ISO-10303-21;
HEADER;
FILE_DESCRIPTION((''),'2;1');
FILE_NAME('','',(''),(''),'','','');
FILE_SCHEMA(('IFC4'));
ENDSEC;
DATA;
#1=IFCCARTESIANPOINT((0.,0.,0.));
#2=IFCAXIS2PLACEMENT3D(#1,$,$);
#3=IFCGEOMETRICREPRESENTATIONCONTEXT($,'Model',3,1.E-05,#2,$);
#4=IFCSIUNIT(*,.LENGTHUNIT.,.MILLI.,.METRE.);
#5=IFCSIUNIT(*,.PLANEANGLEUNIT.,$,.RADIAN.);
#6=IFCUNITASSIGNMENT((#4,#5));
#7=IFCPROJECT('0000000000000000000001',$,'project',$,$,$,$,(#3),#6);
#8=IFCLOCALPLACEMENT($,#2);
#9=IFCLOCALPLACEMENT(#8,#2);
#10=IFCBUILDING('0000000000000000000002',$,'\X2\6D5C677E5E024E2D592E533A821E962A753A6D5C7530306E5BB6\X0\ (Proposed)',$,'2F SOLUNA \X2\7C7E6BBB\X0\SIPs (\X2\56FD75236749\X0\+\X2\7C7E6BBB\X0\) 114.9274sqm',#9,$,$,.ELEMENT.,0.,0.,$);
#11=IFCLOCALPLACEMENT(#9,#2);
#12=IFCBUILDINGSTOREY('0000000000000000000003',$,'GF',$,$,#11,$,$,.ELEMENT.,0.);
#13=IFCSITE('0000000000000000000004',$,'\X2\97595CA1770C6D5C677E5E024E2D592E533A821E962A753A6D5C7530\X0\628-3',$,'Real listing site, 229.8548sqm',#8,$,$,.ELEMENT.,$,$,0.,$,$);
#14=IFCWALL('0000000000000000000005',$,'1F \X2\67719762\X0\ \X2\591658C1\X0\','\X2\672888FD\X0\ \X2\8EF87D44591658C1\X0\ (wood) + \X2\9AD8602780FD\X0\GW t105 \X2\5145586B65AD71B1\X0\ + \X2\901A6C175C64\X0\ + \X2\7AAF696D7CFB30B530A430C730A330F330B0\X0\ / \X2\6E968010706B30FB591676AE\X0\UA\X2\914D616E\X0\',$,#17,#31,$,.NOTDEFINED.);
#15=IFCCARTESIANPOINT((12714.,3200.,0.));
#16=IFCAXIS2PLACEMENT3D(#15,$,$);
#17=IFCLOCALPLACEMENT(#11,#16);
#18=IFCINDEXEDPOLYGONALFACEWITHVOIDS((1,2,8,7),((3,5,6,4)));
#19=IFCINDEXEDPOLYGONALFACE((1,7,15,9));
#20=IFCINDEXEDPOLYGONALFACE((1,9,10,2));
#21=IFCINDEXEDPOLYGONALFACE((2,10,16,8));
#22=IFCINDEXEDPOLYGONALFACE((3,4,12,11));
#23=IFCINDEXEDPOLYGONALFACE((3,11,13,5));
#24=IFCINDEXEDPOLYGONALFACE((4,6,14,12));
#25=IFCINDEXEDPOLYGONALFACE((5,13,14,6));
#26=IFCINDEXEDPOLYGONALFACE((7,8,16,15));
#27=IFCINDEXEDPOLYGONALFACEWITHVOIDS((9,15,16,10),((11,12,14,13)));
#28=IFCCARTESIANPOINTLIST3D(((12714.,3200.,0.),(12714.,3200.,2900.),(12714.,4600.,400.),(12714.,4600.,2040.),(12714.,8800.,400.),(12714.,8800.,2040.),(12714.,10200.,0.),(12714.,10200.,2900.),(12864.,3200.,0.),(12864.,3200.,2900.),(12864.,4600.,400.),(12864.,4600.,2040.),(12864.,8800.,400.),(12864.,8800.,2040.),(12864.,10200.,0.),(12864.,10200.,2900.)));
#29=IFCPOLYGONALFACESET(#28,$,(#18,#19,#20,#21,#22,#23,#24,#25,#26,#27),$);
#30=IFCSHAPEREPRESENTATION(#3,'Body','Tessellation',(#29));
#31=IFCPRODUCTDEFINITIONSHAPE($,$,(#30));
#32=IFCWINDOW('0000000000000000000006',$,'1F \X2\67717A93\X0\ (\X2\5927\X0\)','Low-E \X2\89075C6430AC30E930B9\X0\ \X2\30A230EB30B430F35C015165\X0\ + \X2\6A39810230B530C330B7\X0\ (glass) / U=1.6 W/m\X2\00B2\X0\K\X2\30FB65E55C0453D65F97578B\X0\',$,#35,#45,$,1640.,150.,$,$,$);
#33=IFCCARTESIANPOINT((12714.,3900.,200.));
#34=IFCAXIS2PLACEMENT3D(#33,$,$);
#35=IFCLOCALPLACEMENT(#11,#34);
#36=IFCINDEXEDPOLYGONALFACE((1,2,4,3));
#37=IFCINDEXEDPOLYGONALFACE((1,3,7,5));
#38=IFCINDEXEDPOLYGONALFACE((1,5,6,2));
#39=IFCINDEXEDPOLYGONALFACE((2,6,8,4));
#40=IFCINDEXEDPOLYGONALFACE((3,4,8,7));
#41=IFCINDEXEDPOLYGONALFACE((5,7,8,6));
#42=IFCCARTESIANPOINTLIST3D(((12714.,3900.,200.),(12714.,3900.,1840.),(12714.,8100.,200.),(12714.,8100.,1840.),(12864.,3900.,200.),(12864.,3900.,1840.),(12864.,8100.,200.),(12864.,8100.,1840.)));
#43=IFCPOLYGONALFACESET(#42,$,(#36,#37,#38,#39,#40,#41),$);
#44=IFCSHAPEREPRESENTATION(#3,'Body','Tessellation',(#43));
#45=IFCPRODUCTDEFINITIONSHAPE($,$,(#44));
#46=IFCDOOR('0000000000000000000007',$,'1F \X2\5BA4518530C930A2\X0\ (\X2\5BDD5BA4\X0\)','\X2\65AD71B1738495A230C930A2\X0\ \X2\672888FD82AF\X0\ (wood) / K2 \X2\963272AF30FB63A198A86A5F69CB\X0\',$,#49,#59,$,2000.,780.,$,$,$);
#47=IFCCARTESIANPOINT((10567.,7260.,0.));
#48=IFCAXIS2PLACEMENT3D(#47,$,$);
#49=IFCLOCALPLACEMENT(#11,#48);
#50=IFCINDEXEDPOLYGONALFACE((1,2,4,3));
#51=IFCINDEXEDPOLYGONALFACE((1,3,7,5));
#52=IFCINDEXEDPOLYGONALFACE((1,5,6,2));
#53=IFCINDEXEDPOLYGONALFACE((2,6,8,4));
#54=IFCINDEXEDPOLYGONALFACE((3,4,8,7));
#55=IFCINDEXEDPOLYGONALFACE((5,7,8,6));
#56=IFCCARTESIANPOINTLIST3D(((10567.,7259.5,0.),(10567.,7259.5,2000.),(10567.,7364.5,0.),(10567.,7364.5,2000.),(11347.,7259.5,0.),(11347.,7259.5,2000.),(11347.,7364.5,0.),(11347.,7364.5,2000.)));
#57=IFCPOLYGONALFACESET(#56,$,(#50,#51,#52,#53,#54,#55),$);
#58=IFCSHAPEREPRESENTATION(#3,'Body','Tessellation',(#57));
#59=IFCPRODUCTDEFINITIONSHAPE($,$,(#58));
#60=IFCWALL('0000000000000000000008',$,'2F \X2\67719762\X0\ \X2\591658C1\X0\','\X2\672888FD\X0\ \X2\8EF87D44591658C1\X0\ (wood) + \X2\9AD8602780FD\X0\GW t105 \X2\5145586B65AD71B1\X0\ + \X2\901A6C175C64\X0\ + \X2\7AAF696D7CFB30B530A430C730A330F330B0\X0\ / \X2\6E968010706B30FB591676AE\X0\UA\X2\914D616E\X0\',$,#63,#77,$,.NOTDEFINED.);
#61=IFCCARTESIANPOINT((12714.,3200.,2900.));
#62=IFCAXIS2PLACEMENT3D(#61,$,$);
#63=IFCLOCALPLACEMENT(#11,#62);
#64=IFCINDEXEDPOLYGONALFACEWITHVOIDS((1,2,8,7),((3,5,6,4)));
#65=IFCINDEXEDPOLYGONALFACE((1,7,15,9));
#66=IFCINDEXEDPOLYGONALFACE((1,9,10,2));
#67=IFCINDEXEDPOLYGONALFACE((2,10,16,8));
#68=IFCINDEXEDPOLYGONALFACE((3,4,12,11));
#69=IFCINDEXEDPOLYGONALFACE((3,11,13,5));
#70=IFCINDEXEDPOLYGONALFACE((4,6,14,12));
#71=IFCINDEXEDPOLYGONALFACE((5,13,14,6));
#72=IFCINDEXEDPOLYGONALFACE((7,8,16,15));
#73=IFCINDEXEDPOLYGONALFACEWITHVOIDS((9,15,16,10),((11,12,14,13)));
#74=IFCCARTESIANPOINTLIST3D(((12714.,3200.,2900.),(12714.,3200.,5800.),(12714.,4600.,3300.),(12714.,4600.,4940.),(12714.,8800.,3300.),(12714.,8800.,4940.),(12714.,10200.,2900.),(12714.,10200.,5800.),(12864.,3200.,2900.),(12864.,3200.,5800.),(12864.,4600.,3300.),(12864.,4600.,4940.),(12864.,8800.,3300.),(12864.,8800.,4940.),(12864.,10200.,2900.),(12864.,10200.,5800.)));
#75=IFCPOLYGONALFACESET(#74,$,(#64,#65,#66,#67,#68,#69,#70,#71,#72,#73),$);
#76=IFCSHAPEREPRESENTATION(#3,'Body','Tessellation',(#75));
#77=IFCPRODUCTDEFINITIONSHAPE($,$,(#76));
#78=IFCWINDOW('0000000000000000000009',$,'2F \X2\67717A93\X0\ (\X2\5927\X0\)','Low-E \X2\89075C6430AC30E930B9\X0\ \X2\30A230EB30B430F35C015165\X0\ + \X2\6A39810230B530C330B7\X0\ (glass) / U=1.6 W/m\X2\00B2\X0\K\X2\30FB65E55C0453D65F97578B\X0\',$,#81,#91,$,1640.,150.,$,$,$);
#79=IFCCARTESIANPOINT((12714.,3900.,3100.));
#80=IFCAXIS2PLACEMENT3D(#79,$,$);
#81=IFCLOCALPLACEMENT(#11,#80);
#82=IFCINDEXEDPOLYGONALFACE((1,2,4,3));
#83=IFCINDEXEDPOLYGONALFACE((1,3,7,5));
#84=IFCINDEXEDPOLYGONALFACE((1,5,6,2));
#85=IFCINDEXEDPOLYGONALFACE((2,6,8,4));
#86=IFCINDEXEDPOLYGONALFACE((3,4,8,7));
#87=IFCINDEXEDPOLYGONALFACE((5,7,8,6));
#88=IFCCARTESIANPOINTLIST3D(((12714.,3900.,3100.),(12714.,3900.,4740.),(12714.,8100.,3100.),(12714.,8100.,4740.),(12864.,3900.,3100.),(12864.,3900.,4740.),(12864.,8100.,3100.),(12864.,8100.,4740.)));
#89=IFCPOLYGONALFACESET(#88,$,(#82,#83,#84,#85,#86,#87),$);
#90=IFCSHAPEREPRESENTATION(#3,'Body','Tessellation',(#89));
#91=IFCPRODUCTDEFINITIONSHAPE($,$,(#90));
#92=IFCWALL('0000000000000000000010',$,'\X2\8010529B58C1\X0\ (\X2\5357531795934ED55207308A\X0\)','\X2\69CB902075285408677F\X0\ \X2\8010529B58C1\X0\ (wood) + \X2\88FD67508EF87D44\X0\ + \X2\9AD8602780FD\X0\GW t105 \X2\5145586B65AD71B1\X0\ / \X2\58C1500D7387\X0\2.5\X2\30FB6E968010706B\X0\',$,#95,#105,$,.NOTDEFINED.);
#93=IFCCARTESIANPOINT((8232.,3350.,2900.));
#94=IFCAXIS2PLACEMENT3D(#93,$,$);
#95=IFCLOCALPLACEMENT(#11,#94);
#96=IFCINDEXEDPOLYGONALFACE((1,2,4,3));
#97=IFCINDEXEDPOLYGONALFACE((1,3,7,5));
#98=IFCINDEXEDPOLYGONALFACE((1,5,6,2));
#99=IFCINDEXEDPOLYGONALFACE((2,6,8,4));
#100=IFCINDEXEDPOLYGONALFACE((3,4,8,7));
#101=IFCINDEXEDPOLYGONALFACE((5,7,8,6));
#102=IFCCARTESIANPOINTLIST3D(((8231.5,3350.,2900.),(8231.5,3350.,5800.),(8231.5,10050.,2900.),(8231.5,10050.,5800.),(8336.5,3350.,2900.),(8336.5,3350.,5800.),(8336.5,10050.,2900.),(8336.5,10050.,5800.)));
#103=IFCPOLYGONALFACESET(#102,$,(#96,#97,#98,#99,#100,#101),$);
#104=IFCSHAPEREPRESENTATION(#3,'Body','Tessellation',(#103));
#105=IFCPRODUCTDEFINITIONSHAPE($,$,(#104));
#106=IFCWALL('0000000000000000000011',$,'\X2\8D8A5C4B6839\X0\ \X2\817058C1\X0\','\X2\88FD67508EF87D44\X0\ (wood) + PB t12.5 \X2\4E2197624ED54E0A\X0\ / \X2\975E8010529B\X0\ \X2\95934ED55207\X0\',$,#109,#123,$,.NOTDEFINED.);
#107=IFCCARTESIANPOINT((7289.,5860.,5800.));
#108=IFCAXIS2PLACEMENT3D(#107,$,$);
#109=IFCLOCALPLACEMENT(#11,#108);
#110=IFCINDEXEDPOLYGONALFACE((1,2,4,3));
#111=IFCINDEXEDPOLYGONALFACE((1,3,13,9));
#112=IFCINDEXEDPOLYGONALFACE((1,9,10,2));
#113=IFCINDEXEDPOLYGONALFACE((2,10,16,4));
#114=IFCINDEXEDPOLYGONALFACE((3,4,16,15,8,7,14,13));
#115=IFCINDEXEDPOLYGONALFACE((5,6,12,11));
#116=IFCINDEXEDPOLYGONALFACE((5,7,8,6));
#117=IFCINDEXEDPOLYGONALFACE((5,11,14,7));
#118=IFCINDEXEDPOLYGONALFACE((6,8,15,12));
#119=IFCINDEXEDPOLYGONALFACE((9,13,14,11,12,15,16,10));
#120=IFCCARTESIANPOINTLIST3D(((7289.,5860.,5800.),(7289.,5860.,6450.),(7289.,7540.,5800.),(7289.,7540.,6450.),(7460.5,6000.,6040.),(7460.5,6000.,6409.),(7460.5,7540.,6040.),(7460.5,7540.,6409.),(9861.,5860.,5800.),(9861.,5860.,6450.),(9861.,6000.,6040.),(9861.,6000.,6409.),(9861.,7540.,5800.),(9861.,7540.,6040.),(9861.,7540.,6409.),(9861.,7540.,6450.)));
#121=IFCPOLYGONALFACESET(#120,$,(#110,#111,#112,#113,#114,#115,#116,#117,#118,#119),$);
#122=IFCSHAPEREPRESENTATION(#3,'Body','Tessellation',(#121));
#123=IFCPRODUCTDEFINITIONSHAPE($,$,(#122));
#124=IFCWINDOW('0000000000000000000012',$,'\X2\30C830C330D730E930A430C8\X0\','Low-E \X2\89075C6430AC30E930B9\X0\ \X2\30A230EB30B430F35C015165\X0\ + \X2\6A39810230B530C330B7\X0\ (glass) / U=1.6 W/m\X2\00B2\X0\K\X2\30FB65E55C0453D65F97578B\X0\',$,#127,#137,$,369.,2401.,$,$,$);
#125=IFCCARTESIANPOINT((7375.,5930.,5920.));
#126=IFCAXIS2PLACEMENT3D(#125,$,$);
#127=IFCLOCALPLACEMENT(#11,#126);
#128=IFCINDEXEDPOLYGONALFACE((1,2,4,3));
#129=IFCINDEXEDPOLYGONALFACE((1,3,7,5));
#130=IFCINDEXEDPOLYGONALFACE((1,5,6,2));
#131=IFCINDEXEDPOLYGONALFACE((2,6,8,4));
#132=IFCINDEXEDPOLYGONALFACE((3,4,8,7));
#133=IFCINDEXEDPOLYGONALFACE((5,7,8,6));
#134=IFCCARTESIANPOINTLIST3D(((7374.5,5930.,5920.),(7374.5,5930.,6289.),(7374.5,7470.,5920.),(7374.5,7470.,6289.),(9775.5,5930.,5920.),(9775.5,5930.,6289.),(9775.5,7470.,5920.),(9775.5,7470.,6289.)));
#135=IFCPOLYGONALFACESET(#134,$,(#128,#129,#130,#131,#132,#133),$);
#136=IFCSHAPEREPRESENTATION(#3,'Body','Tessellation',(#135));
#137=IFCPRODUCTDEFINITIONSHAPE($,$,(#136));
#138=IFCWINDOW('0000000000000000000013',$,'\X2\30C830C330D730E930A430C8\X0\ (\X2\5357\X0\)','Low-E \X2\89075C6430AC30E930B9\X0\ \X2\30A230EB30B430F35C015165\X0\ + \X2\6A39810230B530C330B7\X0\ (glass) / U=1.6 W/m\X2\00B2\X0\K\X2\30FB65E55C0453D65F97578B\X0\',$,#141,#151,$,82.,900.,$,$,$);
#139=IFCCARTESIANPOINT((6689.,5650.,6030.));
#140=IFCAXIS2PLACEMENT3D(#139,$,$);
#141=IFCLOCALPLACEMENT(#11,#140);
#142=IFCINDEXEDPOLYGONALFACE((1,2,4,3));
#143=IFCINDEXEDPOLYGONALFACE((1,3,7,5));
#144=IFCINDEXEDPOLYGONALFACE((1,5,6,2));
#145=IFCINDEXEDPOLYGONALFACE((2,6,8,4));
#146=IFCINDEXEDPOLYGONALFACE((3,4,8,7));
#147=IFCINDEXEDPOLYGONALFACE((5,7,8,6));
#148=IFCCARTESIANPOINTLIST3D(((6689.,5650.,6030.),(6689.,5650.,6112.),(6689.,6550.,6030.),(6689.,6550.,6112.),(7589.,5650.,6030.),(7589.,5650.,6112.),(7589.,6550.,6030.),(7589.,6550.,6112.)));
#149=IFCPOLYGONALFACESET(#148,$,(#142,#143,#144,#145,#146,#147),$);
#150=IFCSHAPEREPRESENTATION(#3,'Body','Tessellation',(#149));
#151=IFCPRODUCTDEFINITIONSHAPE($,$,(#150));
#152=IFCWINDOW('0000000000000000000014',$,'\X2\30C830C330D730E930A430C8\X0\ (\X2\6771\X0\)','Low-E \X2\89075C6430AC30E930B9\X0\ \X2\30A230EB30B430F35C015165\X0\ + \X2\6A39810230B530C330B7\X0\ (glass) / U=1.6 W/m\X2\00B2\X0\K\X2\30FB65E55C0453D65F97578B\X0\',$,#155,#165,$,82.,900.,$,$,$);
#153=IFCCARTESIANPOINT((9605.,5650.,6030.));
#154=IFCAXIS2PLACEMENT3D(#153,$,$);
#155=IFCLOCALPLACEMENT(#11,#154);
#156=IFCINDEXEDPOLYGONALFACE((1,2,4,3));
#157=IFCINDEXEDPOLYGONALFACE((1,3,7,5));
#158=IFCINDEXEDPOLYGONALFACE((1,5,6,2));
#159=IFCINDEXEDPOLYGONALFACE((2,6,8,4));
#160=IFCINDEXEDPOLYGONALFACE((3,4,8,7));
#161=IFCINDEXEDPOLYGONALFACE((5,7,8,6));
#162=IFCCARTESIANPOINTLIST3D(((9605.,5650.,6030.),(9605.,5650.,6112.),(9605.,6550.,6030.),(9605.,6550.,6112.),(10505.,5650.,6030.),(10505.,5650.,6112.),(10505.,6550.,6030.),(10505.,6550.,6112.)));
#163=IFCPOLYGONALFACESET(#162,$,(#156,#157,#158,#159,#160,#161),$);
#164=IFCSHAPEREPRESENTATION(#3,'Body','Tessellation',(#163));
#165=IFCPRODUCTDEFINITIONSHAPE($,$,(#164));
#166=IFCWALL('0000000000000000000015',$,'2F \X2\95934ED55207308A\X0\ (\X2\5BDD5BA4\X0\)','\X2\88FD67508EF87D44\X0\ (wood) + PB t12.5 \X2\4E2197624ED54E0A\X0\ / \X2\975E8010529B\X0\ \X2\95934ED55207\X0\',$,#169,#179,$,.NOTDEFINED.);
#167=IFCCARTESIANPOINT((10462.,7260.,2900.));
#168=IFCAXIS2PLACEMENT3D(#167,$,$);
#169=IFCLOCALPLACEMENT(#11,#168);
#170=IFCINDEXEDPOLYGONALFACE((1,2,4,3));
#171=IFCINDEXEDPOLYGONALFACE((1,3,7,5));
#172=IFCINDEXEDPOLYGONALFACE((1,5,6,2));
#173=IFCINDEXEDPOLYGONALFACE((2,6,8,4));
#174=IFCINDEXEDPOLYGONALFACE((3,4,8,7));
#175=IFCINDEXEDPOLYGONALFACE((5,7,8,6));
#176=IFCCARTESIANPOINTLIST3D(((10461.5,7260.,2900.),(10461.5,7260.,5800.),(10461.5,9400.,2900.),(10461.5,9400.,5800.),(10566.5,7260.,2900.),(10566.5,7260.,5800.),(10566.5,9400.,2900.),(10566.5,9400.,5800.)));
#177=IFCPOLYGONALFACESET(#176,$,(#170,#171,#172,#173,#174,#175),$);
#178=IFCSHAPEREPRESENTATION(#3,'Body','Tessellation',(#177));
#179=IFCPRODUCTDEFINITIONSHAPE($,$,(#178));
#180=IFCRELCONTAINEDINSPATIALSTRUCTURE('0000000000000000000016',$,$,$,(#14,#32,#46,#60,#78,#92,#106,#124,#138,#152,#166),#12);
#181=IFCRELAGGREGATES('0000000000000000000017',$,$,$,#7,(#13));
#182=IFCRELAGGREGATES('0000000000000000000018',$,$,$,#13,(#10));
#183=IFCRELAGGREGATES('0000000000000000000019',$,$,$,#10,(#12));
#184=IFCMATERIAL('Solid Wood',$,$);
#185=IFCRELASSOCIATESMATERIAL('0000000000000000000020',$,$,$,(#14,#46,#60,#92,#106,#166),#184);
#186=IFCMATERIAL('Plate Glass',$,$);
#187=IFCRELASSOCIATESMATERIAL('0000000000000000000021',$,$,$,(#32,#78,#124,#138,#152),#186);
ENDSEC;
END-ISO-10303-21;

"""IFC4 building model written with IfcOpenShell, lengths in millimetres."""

from ifc_helpers import new_model, si_unit, frame, frame_2d, origin, place, context, project, spatial, rectangle, extrude, material, element, fill, save


model = new_model("IFC4")

# Units and contexts
model_context = context("Model", 3, precision=1e-05, world=origin())
ifc_project = project(units=[si_unit("LENGTHUNIT", "METRE", prefix="MILLI"), si_unit("PLANEANGLEUNIT", "RADIAN")], contexts=[model_context])

# Site, building, storey
site_placement = place(None, origin())
site = spatial("IfcSite", under=ifc_project, at=site_placement, Name="静岡県浜松市中央区舞阪町浜田628-3", ObjectType="Real listing site, 229.8548sqm", CompositionType="ELEMENT", RefElevation=0.0)
building_placement = place(site_placement, origin())
building = spatial("IfcBuilding", under=site, at=building_placement, Name="浜松市中央区舞阪町浜田の家 (Proposed)", ObjectType="2F SOLUNA 籾殻SIPs (国産杉+籾殻) 114.9274sqm", CompositionType="ELEMENT", ElevationOfRefHeight=0.0, ElevationOfTerrain=0.0)
storey_placement = place(building_placement, origin())
storey = spatial("IfcBuildingStorey", under=building, at=storey_placement, Name="GF", CompositionType="ELEMENT", Elevation=0.0)

# Wall, opening, window
ifc_material_1 = material(Name="Solid Wood")
wall_1_placement = place(storey_placement, frame((12714.0, 3200.0, 0.0)))
wall_1 = element("IfcWall", 1, at=wall_1_placement, inside=storey, material=ifc_material_1, Name="1F 東面 外壁", Description="木製 軸組外壁 (wood) + 高性能GW t105 充填断熱 + 通気層 + 窯業系サイディング / 準耐火・外皮UA配慮", PredefinedType="NOTDEFINED", context=model_context, shape_type="SweptSolid", body=[
    extrude(rectangle(XDim=150.0, YDim=7000.0, at=frame_2d((75.0, 3500.0))), frame((12714.0, 3200.0, 0.0)), (0.0, 0.0, 1.0), 2900.0),
])
opening_1_placement = place(storey_placement, frame((12714.0, 3900.0, 200.0)))
opening_1 = element("IfcOpeningElement", 2, at=opening_1_placement, cuts=wall_1, PredefinedType="NOTDEFINED", context=model_context, shape_type="SweptSolid", body=[
    extrude(rectangle(XDim=150.0, YDim=4200.0, at=frame_2d((75.0, 2100.0))), frame((12714.0, 3900.0, 200.0)), (0.0, 0.0, 1.0), 1640.0),
])
ifc_material_2 = material(Name="Plate Glass")
window_1_placement = place(storey_placement, frame((12714.0, 3900.0, 200.0)))
window_1 = element("IfcWindow", 3, at=window_1_placement, inside=storey, material=ifc_material_2, Name="1F 東窓 (大)", Description="Low-E 複層ガラス アルゴン封入 + 樹脂サッシ (glass) / U=1.6 W/m²K・日射取得型", OverallHeight=1640.0, OverallWidth=150.0, context=model_context, shape_type="SweptSolid", body=[
    extrude(rectangle(XDim=150.0, YDim=4200.0, at=frame_2d((75.0, 2100.0))), frame((12714.0, 3900.0, 200.0)), (0.0, 0.0, 1.0), 1640.0),
])
fill(opening_1, window_1)

# Door
door_1_placement = place(storey_placement, frame((10567.0, 7260.0, 0.0)))
element("IfcDoor", 4, at=door_1_placement, inside=storey, material=ifc_material_1, Name="1F 室内ドア (寝室)", Description="断熱玄関ドア 木製芯 (wood) / K2 防犯・採風機構", OverallHeight=2000.0, OverallWidth=780.0, context=model_context, shape_type="SweptSolid", body=[
    extrude(rectangle(XDim=780.0, YDim=105.0, at=frame_2d((390.0, 52.0))), frame((10567.0, 7260.0, 0.0)), (0.0, 0.0, 1.0), 2000.0),
])

# Wall, opening, window
wall_2_placement = place(storey_placement, frame((12714.0, 3200.0, 2900.0)))
wall_2 = element("IfcWall", 5, at=wall_2_placement, inside=storey, material=ifc_material_1, Name="2F 東面 外壁", Description="木製 軸組外壁 (wood) + 高性能GW t105 充填断熱 + 通気層 + 窯業系サイディング / 準耐火・外皮UA配慮", PredefinedType="NOTDEFINED", context=model_context, shape_type="SweptSolid", body=[
    extrude(rectangle(XDim=150.0, YDim=7000.0, at=frame_2d((75.0, 3500.0))), frame((12714.0, 3200.0, 2900.0)), (0.0, 0.0, 1.0), 2900.0),
])
opening_2_placement = place(storey_placement, frame((12714.0, 3900.0, 3100.0)))
opening_2 = element("IfcOpeningElement", 6, at=opening_2_placement, cuts=wall_2, PredefinedType="NOTDEFINED", context=model_context, shape_type="SweptSolid", body=[
    extrude(rectangle(XDim=150.0, YDim=4200.0, at=frame_2d((75.0, 2100.0))), frame((12714.0, 3900.0, 3100.0)), (0.0, 0.0, 1.0), 1640.0),
])
window_2_placement = place(storey_placement, frame((12714.0, 3900.0, 3100.0)))
window_2 = element("IfcWindow", 7, at=window_2_placement, inside=storey, material=ifc_material_2, Name="2F 東窓 (大)", Description="Low-E 複層ガラス アルゴン封入 + 樹脂サッシ (glass) / U=1.6 W/m²K・日射取得型", OverallHeight=1640.0, OverallWidth=150.0, context=model_context, shape_type="SweptSolid", body=[
    extrude(rectangle(XDim=150.0, YDim=4200.0, at=frame_2d((75.0, 2100.0))), frame((12714.0, 3900.0, 3100.0)), (0.0, 0.0, 1.0), 1640.0),
])
fill(opening_2, window_2)

# Wall
wall_3_placement = place(storey_placement, frame((8232.0, 3350.0, 2900.0)))
element("IfcWall", 8, at=wall_3_placement, inside=storey, material=ifc_material_1, Name="耐力壁 (南北間仕切り)", Description="構造用合板 耐力壁 (wood) + 製材軸組 + 高性能GW t105 充填断熱 / 壁倍率2.5・準耐火", PredefinedType="NOTDEFINED", context=model_context, shape_type="SweptSolid", body=[
    extrude(rectangle(XDim=105.0, YDim=6700.0, at=frame_2d((52.0, 3350.0))), frame((8232.0, 3350.0, 2900.0)), (0.0, 0.0, 1.0), 2900.0),
])

# Wall, openings, windows
wall_4_placement = place(storey_placement, frame((7289.0, 5860.0, 5800.0)))
wall_4 = element("IfcWall", 9, at=wall_4_placement, inside=storey, material=ifc_material_1, Name="越屋根 腰壁", Description="製材軸組 (wood) + PB t12.5 両面仕上 / 非耐力 間仕切", PredefinedType="NOTDEFINED", context=model_context, shape_type="SweptSolid", body=[
    extrude(rectangle(XDim=2572.0, YDim=1680.0, at=frame_2d((1286.0, 840.0))), frame((7289.0, 5860.0, 5800.0)), (0.0, 0.0, 1.0), 650.0),
])
opening_3_placement = place(storey_placement, frame((7375.0, 5930.0, 5920.0)))
opening_3 = element("IfcOpeningElement", 10, at=opening_3_placement, cuts=wall_4, PredefinedType="NOTDEFINED", context=model_context, shape_type="SweptSolid", body=[
    extrude(rectangle(XDim=2401.0, YDim=1540.0, at=frame_2d((1200.0, 770.0))), frame((7375.0, 5930.0, 5920.0)), (0.0, 0.0, 1.0), 369.0),
])
opening_4_placement = place(storey_placement, frame((6689.0, 5650.0, 6030.0)))
opening_4 = element("IfcOpeningElement", 11, at=opening_4_placement, cuts=wall_4, PredefinedType="NOTDEFINED", context=model_context, shape_type="SweptSolid", body=[
    extrude(rectangle(XDim=900.0, YDim=900.0, at=frame_2d((450.0, 450.0))), frame((6689.0, 5650.0, 6030.0)), (0.0, 0.0, 1.0), 82.0),
])
opening_5_placement = place(storey_placement, frame((9605.0, 5650.0, 6030.0)))
opening_5 = element("IfcOpeningElement", 12, at=opening_5_placement, cuts=wall_4, PredefinedType="NOTDEFINED", context=model_context, shape_type="SweptSolid", body=[
    extrude(rectangle(XDim=900.0, YDim=900.0, at=frame_2d((450.0, 450.0))), frame((9605.0, 5650.0, 6030.0)), (0.0, 0.0, 1.0), 82.0),
])
window_3_placement = place(storey_placement, frame((7375.0, 5930.0, 5920.0)))
window_3 = element("IfcWindow", 13, at=window_3_placement, inside=storey, material=ifc_material_2, Name="トップライト", Description="Low-E 複層ガラス アルゴン封入 + 樹脂サッシ (glass) / U=1.6 W/m²K・日射取得型", OverallHeight=369.0, OverallWidth=2401.0, context=model_context, shape_type="SweptSolid", body=[
    extrude(rectangle(XDim=2401.0, YDim=1540.0, at=frame_2d((1200.0, 770.0))), frame((7375.0, 5930.0, 5920.0)), (0.0, 0.0, 1.0), 369.0),
])
fill(opening_3, window_3)
window_4_placement = place(storey_placement, frame((6689.0, 5650.0, 6030.0)))
window_4 = element("IfcWindow", 14, at=window_4_placement, inside=storey, material=ifc_material_2, Name="トップライト (南)", Description="Low-E 複層ガラス アルゴン封入 + 樹脂サッシ (glass) / U=1.6 W/m²K・日射取得型", OverallHeight=82.0, OverallWidth=900.0, context=model_context, shape_type="SweptSolid", body=[
    extrude(rectangle(XDim=900.0, YDim=900.0, at=frame_2d((450.0, 450.0))), frame((6689.0, 5650.0, 6030.0)), (0.0, 0.0, 1.0), 82.0),
])
fill(opening_4, window_4)
window_5_placement = place(storey_placement, frame((9605.0, 5650.0, 6030.0)))
window_5 = element("IfcWindow", 15, at=window_5_placement, inside=storey, material=ifc_material_2, Name="トップライト (東)", Description="Low-E 複層ガラス アルゴン封入 + 樹脂サッシ (glass) / U=1.6 W/m²K・日射取得型", OverallHeight=82.0, OverallWidth=900.0, context=model_context, shape_type="SweptSolid", body=[
    extrude(rectangle(XDim=900.0, YDim=900.0, at=frame_2d((450.0, 450.0))), frame((9605.0, 5650.0, 6030.0)), (0.0, 0.0, 1.0), 82.0),
])
fill(opening_5, window_5)

# Wall
wall_5_placement = place(storey_placement, frame((10462.0, 7260.0, 2900.0)))
element("IfcWall", 16, at=wall_5_placement, inside=storey, material=ifc_material_1, Name="2F 間仕切り (寝室)", Description="製材軸組 (wood) + PB t12.5 両面仕上 / 非耐力 間仕切", PredefinedType="NOTDEFINED", context=model_context, shape_type="SweptSolid", body=[
    extrude(rectangle(XDim=105.0, YDim=2140.0, at=frame_2d((52.0, 1070.0))), frame((10462.0, 7260.0, 2900.0)), (0.0, 0.0, 1.0), 2900.0),
])

save(model, "model.ifc")
